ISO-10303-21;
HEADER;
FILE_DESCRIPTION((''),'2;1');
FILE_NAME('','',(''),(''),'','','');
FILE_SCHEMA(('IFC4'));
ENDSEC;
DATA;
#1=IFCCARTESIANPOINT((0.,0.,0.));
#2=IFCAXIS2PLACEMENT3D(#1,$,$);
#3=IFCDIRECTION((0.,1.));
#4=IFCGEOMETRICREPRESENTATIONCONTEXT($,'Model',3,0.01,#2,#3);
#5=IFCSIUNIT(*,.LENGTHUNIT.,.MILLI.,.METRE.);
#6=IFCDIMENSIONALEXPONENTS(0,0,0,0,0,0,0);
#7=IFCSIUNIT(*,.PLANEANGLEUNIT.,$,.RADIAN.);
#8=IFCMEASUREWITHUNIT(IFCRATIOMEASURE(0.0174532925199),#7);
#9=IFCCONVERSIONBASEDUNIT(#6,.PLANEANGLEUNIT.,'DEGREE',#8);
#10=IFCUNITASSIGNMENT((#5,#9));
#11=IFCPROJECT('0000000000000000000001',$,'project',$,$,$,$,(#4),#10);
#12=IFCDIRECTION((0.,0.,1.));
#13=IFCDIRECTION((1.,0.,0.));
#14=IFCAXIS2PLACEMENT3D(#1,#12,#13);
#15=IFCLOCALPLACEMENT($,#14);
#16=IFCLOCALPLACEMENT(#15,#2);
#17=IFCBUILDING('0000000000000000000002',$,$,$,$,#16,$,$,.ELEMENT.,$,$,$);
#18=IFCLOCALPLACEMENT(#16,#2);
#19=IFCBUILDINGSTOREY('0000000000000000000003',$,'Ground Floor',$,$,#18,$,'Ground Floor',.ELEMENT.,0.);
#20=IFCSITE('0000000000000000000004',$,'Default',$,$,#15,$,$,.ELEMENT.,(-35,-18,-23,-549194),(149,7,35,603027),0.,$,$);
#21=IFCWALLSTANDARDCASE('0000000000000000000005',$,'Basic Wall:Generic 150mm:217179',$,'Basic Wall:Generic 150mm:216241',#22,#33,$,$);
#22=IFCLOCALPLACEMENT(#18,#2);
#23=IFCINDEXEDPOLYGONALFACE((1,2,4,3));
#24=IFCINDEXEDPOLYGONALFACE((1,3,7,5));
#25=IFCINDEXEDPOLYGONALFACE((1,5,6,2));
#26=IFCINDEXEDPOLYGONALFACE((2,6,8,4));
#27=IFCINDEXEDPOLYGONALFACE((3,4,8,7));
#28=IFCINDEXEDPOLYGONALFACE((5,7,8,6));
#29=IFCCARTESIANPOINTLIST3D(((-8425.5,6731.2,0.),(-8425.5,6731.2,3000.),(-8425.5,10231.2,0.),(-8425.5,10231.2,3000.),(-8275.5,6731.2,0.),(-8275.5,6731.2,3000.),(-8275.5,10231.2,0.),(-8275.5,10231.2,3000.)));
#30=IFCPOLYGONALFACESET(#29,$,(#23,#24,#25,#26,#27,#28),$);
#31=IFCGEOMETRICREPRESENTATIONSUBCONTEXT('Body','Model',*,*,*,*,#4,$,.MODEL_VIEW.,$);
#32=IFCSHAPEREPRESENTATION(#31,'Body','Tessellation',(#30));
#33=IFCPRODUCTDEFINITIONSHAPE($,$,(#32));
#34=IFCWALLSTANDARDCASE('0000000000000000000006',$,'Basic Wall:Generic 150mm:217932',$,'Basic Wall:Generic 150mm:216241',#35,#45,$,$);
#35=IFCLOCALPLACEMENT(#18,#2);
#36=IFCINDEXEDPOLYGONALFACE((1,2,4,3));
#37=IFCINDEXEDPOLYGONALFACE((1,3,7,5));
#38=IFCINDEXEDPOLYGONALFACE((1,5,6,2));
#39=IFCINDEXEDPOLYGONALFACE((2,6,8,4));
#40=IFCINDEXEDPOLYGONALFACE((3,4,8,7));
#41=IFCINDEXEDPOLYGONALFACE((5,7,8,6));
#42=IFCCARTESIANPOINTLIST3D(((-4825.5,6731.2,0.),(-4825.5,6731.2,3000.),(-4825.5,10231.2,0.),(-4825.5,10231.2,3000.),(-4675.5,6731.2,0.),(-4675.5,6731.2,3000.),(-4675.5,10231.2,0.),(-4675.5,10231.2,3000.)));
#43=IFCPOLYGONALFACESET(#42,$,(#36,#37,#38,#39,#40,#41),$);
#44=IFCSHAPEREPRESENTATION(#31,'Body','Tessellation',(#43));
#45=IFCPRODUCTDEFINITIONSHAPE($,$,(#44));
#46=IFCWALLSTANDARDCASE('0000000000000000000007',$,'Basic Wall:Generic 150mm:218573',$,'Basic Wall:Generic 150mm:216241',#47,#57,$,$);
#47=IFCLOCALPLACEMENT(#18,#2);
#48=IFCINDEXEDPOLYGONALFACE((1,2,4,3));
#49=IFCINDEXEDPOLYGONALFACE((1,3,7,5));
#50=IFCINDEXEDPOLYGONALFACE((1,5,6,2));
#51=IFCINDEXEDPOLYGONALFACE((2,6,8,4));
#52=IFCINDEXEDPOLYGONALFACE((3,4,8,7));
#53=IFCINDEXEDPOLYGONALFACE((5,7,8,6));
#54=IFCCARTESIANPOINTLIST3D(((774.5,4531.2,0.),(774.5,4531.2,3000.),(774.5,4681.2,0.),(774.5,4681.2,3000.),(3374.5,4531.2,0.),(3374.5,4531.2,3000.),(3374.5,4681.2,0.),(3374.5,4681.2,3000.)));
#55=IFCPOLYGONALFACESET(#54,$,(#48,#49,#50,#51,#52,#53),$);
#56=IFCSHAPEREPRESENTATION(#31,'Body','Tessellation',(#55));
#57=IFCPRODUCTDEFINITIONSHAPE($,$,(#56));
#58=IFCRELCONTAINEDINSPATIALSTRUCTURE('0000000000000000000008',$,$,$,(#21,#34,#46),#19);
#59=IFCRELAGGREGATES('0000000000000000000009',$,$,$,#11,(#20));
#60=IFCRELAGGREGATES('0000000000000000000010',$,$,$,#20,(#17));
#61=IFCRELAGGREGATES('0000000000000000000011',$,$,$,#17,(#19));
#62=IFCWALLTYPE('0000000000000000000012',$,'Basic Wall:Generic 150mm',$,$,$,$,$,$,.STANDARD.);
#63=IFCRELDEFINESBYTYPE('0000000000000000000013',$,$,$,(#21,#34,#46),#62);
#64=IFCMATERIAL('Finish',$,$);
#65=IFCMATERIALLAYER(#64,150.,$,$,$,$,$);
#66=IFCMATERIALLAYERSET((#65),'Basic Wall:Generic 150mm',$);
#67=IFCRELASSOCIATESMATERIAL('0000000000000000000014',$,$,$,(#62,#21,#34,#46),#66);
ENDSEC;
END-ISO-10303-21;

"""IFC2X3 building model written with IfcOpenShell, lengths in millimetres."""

from ifc_helpers import new_model, entity, si_unit, converted_unit, direction, frame, frame_2d, origin, origin_with_axes, place, context, subcontext, project, spatial, rectangle, extrude, material, layer, layer_set, layer_usage, type_object, element, save


model = new_model("IFC2X3")

# Units and contexts
model_context = context("Model", 3, precision=0.01, world=origin(), true_north=direction((0.0, 1.0)))
body_context = subcontext(model_context, "Body", "Model", "MODEL_VIEW")
ifc_project = project(units=[si_unit("LENGTHUNIT", "METRE", prefix="MILLI"), converted_unit("PLANEANGLEUNIT", "DEGREE", entity("IfcRatioMeasure", 0.0174532925199), si_unit("PLANEANGLEUNIT", "RADIAN"), dimensions=[0, 0, 0, 0, 0, 0, 0])], contexts=[model_context])

# Site, building, storey
site_placement = place(None, origin_with_axes())
site = spatial("IfcSite", under=ifc_project, at=site_placement, Name="Default", CompositionType="ELEMENT", RefLatitude=(-35, -18, -23, -549194), RefLongitude=(149, 7, 35, 603027), RefElevation=0.0)
building_placement = place(site_placement, origin())
building = spatial("IfcBuilding", under=site, at=building_placement, CompositionType="ELEMENT")
storey_placement = place(building_placement, origin())
storey = spatial("IfcBuildingStorey", under=building, at=storey_placement, Name="Ground Floor", LongName="Ground Floor", CompositionType="ELEMENT", Elevation=0.0)

# Shared definitions
ifc_material_1 = material(Name="Finish")

# Walls
ifc_layer_1 = layer(ifc_material_1, 150.0)
ifc_layer_set_1 = layer_set([ifc_layer_1], Name="Basic Wall:Generic 150mm")
wall_type_1 = type_object("IfcWallType", Name="Basic Wall:Generic 150mm", PredefinedType="STANDARD", material=ifc_layer_set_1)
ifc_layer_usage_1 = layer_usage(ifc_layer_set_1, "AXIS2", "POSITIVE", -75.0)
wall_1_placement = place(storey_placement, frame((-8350.5, 6731.2, 0.0), z_axis=(0.0, 0.0, 1.0), x_axis=(0.0, 1.0, 0.0)))
element("IfcWallStandardCase", 1, at=wall_1_placement, inside=storey, type_object=wall_type_1, material=ifc_layer_usage_1, Name="Basic Wall:Generic 150mm:217179", ObjectType="Basic Wall:Generic 150mm:216241", context=body_context, shape_type="SweptSolid", body=[
    extrude(rectangle(XDim=3500.0, YDim=150.0, at=frame_2d((1750.0, 0.0), x_axis=(-1.0, 0.0))), origin(), (0.0, 0.0, 1.0), 3000.0),
])
ifc_layer_usage_2 = layer_usage(ifc_layer_set_1, "AXIS2", "NEGATIVE", 75.0)
wall_2_placement = place(storey_placement, frame((-4750.5, 10231.2, 0.0), z_axis=(0.0, 0.0, 1.0), x_axis=(0.0, -1.0, 0.0)))
element("IfcWallStandardCase", 2, at=wall_2_placement, inside=storey, type_object=wall_type_1, material=ifc_layer_usage_2, Name="Basic Wall:Generic 150mm:217932", ObjectType="Basic Wall:Generic 150mm:216241", context=body_context, shape_type="SweptSolid", body=[
    extrude(rectangle(XDim=3500.0, YDim=150.0, at=frame_2d((1750.0, 0.0), x_axis=(-1.0, 0.0))), origin(), (0.0, 0.0, 1.0), 3000.0),
])
ifc_layer_usage_3 = layer_usage(ifc_layer_set_1, "AXIS2", "NEGATIVE", 75.0)
wall_3_placement = place(storey_placement, frame((774.5, 4606.2, 0.0)))
element("IfcWallStandardCase", 3, at=wall_3_placement, inside=storey, type_object=wall_type_1, material=ifc_layer_usage_3, Name="Basic Wall:Generic 150mm:218573", ObjectType="Basic Wall:Generic 150mm:216241", context=body_context, shape_type="SweptSolid", body=[
    extrude(rectangle(XDim=2600.0, YDim=150.0, at=frame_2d((1300.0, 0.0), x_axis=(-1.0, 0.0))), origin(), (0.0, 0.0, 1.0), 3000.0),
])

save(model, "model.ifc")
